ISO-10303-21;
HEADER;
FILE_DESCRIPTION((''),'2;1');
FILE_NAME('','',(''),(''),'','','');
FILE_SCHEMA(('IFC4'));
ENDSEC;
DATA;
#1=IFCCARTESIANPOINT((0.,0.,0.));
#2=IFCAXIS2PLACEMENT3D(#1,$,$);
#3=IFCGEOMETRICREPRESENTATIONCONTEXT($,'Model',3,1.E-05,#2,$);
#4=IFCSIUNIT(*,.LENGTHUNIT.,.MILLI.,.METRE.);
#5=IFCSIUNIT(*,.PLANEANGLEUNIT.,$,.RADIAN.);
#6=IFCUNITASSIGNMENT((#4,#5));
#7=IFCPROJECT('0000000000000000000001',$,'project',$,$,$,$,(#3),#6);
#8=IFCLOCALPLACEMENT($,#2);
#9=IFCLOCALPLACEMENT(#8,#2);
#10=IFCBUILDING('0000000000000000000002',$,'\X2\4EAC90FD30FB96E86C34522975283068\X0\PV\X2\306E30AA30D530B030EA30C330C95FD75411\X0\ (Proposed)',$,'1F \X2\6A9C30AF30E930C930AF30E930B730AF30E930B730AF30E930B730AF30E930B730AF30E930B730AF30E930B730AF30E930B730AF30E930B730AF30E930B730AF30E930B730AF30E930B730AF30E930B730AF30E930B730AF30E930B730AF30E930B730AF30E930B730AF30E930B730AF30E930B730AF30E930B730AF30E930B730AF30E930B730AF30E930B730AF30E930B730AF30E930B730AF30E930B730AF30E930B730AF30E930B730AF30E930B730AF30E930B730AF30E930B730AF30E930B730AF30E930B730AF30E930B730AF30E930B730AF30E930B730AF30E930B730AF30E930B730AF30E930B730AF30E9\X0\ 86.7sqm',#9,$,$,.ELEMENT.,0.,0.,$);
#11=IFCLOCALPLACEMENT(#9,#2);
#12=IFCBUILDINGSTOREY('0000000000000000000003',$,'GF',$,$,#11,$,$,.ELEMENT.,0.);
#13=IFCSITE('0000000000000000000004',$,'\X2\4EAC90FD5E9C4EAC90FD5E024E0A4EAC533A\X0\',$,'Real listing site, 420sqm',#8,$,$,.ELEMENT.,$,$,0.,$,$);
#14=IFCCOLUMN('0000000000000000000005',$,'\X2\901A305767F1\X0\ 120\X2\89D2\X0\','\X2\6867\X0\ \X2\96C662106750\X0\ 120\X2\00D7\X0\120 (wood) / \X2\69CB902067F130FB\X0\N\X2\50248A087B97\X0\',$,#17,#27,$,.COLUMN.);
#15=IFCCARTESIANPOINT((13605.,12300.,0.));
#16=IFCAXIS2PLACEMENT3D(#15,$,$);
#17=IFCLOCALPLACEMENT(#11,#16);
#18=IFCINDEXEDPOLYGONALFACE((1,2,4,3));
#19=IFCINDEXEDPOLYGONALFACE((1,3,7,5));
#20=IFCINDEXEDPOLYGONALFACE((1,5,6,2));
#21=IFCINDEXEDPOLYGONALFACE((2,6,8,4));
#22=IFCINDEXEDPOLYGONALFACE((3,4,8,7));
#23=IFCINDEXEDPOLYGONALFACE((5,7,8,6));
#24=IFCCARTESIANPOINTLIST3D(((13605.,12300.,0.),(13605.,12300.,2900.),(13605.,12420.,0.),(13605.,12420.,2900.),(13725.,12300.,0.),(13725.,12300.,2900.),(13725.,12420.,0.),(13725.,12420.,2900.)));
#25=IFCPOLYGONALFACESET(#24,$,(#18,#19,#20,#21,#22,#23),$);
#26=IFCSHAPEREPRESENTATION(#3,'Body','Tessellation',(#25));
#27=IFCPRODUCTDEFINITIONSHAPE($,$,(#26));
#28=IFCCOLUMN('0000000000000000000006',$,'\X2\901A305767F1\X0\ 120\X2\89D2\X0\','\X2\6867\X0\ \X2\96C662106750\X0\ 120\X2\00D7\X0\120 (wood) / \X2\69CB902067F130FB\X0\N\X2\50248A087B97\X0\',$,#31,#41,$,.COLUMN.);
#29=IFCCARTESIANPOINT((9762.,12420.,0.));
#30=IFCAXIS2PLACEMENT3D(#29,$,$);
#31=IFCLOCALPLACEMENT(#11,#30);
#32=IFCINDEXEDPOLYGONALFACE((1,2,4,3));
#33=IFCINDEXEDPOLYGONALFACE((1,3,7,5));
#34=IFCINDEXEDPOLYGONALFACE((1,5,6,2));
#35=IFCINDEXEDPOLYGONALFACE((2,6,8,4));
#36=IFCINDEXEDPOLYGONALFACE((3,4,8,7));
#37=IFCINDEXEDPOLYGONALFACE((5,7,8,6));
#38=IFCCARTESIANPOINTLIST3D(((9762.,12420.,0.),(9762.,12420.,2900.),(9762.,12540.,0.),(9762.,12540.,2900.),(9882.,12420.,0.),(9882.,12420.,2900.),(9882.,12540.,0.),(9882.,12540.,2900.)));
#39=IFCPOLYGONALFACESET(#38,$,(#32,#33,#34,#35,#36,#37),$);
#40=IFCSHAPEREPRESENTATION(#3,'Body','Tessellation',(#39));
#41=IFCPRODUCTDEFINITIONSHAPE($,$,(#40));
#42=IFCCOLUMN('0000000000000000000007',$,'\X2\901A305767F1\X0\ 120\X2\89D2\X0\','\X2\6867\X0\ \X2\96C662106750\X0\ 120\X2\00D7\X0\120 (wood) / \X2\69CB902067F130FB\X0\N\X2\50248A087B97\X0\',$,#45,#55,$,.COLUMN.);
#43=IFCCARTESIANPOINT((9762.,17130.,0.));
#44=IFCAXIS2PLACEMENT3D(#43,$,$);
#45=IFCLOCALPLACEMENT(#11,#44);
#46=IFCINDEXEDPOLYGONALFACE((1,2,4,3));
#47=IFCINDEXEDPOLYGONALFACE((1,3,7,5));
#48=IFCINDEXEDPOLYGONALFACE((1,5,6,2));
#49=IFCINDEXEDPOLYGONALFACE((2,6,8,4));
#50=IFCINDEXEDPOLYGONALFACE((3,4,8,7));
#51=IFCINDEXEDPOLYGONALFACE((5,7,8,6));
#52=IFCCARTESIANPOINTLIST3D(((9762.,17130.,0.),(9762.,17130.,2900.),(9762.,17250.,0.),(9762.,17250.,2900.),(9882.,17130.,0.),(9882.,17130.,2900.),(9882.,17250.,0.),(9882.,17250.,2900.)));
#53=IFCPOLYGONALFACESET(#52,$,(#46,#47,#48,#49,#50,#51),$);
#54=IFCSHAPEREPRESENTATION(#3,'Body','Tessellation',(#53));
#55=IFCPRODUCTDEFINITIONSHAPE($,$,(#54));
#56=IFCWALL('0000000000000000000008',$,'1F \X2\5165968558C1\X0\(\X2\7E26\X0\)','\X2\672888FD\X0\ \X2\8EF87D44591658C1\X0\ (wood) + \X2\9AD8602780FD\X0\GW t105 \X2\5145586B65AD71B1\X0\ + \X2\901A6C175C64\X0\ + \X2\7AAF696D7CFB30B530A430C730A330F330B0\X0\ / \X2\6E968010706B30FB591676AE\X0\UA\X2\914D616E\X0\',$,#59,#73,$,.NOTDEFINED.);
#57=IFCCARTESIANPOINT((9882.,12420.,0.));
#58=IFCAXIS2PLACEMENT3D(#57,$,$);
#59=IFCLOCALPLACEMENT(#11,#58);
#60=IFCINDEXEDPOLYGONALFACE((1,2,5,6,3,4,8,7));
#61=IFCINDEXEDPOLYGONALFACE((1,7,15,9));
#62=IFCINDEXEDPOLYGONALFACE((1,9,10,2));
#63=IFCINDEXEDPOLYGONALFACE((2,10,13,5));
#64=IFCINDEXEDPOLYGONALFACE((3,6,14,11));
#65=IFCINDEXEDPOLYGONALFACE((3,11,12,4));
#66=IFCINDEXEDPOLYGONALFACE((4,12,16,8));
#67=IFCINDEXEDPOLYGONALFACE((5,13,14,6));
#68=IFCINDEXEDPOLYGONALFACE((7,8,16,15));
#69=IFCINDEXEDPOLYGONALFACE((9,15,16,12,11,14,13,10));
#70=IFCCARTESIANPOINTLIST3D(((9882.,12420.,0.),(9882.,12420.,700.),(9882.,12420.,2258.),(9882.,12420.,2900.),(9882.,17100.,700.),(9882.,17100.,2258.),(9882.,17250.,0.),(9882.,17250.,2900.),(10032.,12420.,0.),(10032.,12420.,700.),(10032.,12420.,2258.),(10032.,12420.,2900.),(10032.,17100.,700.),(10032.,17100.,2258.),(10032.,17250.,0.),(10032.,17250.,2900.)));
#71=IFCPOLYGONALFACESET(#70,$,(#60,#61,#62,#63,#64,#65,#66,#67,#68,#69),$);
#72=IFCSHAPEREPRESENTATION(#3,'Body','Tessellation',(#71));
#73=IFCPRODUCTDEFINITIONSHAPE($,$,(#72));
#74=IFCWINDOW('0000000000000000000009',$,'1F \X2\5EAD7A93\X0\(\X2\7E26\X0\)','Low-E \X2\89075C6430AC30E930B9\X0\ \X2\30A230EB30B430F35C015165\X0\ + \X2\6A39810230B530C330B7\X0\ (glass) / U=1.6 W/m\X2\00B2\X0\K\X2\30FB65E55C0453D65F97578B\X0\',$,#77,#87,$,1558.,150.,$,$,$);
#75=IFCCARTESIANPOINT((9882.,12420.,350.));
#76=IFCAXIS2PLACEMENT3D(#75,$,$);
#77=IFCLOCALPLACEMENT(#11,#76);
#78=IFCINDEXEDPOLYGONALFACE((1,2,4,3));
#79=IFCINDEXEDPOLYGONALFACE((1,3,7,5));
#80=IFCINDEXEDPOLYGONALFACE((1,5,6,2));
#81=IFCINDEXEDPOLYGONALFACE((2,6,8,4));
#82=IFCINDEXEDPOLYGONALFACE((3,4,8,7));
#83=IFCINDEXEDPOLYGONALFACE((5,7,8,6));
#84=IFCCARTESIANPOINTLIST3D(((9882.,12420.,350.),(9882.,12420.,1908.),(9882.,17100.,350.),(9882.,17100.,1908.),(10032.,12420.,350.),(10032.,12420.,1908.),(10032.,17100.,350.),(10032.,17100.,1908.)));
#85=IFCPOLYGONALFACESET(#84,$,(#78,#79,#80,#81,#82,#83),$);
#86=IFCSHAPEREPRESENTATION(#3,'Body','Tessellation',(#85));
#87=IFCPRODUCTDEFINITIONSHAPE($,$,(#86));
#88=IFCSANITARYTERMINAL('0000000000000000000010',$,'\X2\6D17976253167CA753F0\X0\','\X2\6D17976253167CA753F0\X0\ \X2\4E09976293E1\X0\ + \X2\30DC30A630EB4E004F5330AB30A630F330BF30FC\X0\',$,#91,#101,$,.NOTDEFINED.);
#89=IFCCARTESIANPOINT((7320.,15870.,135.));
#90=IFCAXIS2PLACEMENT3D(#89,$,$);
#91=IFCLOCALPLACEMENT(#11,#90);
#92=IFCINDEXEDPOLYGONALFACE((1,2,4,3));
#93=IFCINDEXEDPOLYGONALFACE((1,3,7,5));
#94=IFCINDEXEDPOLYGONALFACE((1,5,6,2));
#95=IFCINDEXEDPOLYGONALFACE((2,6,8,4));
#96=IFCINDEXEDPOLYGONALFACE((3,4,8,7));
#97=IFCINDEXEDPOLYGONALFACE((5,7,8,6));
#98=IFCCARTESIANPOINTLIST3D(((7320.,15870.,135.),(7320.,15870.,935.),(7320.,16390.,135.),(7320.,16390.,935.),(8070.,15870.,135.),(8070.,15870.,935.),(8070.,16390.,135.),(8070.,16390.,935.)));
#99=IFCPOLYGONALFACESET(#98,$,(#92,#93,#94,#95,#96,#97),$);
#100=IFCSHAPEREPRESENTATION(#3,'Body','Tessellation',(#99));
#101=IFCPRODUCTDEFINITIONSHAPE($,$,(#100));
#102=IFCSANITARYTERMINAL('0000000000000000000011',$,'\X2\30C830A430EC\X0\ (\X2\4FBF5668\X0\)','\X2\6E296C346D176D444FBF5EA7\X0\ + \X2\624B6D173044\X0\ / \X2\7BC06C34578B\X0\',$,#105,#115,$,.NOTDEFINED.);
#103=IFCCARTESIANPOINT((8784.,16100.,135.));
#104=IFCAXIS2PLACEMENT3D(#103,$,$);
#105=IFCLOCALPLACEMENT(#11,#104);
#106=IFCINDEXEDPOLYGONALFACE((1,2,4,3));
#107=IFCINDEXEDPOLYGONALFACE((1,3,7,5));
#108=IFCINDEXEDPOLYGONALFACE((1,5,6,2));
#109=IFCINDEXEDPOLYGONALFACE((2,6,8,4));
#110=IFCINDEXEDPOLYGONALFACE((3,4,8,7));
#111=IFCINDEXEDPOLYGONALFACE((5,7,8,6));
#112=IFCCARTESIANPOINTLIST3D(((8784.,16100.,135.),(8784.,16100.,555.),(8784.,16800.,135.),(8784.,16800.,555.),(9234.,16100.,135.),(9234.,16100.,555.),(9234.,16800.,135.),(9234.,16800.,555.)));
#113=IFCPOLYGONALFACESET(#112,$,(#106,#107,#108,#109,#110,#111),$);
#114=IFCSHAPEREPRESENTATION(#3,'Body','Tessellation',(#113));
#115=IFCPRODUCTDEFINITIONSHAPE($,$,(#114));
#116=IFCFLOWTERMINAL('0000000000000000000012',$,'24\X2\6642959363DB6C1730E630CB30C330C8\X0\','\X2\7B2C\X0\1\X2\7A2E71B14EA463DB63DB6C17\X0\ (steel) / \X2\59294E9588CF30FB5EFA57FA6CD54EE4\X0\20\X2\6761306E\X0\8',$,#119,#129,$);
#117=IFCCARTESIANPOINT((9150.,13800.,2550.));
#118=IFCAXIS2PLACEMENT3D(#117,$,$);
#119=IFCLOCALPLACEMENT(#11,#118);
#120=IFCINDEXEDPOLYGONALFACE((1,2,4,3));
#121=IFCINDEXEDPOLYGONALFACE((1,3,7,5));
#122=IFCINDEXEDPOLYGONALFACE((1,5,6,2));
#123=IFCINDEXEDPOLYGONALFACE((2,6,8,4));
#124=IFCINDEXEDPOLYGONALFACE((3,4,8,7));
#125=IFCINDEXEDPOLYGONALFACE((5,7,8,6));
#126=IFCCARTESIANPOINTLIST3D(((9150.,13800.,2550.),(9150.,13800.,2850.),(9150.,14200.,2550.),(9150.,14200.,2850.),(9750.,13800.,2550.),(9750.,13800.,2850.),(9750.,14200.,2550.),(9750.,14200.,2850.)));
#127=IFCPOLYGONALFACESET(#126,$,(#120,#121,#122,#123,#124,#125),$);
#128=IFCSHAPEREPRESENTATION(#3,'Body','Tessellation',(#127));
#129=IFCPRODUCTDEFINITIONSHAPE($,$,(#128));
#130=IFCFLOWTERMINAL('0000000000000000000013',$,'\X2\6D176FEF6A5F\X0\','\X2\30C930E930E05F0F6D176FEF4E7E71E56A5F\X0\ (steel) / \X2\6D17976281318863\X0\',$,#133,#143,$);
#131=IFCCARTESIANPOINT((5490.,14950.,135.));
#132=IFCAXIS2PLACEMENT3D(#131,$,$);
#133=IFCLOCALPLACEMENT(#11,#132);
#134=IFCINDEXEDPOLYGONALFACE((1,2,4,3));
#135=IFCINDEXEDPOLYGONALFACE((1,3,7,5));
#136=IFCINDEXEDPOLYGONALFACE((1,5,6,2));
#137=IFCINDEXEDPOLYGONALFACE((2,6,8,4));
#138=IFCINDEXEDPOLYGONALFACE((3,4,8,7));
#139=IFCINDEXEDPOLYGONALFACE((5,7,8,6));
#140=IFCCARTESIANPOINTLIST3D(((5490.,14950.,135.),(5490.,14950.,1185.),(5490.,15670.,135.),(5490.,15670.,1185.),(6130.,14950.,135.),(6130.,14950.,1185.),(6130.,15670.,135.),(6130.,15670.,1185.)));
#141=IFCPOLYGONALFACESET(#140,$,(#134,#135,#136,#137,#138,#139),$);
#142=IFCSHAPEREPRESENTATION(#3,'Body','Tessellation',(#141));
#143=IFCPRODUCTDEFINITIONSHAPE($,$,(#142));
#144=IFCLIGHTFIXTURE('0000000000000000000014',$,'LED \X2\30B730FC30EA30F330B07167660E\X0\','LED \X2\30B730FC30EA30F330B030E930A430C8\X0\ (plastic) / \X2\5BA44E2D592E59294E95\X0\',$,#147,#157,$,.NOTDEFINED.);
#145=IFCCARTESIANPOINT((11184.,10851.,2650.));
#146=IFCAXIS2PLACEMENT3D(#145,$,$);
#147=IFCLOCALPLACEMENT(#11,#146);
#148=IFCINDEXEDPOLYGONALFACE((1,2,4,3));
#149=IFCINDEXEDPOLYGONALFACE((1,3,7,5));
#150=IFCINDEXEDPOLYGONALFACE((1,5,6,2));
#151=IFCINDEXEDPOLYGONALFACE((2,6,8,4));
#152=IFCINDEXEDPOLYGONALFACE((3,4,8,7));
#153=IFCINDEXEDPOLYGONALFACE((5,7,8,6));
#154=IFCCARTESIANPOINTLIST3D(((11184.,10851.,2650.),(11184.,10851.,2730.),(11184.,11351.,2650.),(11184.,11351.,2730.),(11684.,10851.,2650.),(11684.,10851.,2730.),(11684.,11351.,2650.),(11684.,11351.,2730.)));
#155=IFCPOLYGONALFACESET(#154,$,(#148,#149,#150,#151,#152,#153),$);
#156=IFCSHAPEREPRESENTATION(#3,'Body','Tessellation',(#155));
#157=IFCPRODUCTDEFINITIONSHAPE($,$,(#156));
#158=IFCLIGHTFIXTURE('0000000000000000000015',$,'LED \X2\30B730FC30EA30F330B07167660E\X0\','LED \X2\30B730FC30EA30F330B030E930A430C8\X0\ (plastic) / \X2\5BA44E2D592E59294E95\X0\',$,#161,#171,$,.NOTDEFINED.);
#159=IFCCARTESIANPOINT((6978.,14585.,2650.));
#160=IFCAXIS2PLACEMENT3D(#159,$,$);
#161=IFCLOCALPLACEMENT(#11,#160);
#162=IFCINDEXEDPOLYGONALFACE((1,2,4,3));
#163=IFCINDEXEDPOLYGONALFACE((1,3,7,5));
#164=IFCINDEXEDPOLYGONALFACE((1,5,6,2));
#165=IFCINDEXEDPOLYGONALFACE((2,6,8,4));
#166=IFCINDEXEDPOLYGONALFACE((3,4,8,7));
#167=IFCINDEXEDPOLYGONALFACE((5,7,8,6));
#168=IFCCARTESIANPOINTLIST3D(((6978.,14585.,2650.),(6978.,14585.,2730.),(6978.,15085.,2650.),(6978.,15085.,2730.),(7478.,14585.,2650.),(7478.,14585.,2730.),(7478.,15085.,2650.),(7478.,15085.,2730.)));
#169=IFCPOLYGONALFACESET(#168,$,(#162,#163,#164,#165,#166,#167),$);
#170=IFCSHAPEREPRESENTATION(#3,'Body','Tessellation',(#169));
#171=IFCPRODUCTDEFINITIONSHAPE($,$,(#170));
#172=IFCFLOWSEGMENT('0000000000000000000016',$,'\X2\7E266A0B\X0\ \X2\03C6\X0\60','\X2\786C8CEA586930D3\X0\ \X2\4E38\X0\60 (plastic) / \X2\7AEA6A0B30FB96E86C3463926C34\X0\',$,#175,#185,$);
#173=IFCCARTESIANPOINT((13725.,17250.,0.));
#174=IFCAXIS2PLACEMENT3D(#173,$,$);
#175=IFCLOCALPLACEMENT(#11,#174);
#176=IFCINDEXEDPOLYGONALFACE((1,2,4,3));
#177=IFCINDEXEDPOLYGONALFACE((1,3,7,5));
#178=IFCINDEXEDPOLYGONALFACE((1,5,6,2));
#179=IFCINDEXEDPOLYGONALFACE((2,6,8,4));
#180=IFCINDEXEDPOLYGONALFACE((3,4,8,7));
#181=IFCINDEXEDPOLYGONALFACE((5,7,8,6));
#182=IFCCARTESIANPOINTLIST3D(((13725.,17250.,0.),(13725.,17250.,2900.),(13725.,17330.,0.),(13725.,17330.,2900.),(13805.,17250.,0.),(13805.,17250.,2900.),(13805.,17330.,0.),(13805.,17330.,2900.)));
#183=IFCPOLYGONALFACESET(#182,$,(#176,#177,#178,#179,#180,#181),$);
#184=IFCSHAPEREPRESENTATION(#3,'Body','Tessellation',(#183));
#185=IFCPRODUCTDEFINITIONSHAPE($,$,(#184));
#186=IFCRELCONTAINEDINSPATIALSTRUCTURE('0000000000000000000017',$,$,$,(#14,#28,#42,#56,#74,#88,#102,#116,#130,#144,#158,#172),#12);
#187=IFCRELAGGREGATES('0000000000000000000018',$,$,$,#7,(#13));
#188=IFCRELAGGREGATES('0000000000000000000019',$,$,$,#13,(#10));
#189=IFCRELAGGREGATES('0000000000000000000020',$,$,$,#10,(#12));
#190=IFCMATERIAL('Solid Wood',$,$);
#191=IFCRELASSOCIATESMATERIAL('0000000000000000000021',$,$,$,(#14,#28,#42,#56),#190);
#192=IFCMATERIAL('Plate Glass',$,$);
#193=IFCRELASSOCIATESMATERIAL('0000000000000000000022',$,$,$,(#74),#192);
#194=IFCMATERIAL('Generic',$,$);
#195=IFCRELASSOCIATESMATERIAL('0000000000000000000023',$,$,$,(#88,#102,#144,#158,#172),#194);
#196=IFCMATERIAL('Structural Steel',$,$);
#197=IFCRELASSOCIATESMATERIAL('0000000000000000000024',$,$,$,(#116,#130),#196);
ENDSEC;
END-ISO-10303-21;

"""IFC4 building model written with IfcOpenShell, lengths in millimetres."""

from ifc_helpers import new_model, si_unit, frame, frame_2d, origin, place, context, project, spatial, rectangle, extrude, material, element, fill, save


model = new_model("IFC4")

# Units and contexts
model_context = context("Model", 3, precision=1e-05, world=origin())
ifc_project = project(units=[si_unit("LENGTHUNIT", "METRE", prefix="MILLI"), si_unit("PLANEANGLEUNIT", "RADIAN")], contexts=[model_context])

# Site, building, storey
site_placement = place(None, origin())
site = spatial("IfcSite", under=ifc_project, at=site_placement, Name="京都府京都市上京区", ObjectType="Real listing site, 420sqm", CompositionType="ELEMENT", RefElevation=0.0)
building_placement = place(site_placement, origin())
building = spatial("IfcBuilding", under=site, at=building_placement, Name="京都・雨水利用とPVのオフグリッド志向 (Proposed)", ObjectType="1F 檜クラドクラシクラシクラシクラシクラシクラシクラシクラシクラシクラシクラシクラシクラシクラシクラシクラシクラシクラシクラシクラシクラシクラシクラシクラシクラシクラシクラシクラシクラシクラシクラシクラシクラシクラシクラシクラシクラシクラシクラ 86.7sqm", CompositionType="ELEMENT", ElevationOfRefHeight=0.0, ElevationOfTerrain=0.0)
storey_placement = place(building_placement, origin())
storey = spatial("IfcBuildingStorey", under=building, at=storey_placement, Name="GF", CompositionType="ELEMENT", Elevation=0.0)

# Columns
ifc_material_1 = material(Name="Solid Wood")
column_1_placement = place(storey_placement, frame((13605.0, 12300.0, 0.0)))
element("IfcColumn", 1, at=column_1_placement, inside=storey, material=ifc_material_1, Name="通し柱 120角", Description="桧 集成材 120×120 (wood) / 構造柱・N値計算", PredefinedType="COLUMN", context=model_context, shape_type="SweptSolid", body=[
    extrude(rectangle(XDim=120.0, YDim=120.0, at=frame_2d((60.0, 60.0))), frame((13605.0, 12300.0, 0.0)), (0.0, 0.0, 1.0), 2900.0),
])
column_2_placement = place(storey_placement, frame((9762.0, 12420.0, 0.0)))
element("IfcColumn", 2, at=column_2_placement, inside=storey, material=ifc_material_1, Name="通し柱 120角", Description="桧 集成材 120×120 (wood) / 構造柱・N値計算", PredefinedType="COLUMN", context=model_context, shape_type="SweptSolid", body=[
    extrude(rectangle(XDim=120.0, YDim=120.0, at=frame_2d((60.0, 60.0))), frame((9762.0, 12420.0, 0.0)), (0.0, 0.0, 1.0), 2900.0),
])
column_3_placement = place(storey_placement, frame((9762.0, 17130.0, 0.0)))
element("IfcColumn", 3, at=column_3_placement, inside=storey, material=ifc_material_1, Name="通し柱 120角", Description="桧 集成材 120×120 (wood) / 構造柱・N値計算", PredefinedType="COLUMN", context=model_context, shape_type="SweptSolid", body=[
    extrude(rectangle(XDim=120.0, YDim=120.0, at=frame_2d((60.0, 60.0))), frame((9762.0, 17130.0, 0.0)), (0.0, 0.0, 1.0), 2900.0),
])

# Wall, opening, window
wall_1_placement = place(storey_placement, frame((9882.0, 12420.0, 0.0)))
wall_1 = element("IfcWall", 4, at=wall_1_placement, inside=storey, material=ifc_material_1, Name="1F 入隅壁(縦)", Description="木製 軸組外壁 (wood) + 高性能GW t105 充填断熱 + 通気層 + 窯業系サイディング / 準耐火・外皮UA配慮", PredefinedType="NOTDEFINED", context=model_context, shape_type="SweptSolid", body=[
    extrude(rectangle(XDim=150.0, YDim=4830.0, at=frame_2d((75.0, 2415.0))), frame((9882.0, 12420.0, 0.0)), (0.0, 0.0, 1.0), 2900.0),
])
opening_placement = place(storey_placement, frame((9882.0, 12420.0, 350.0)))
opening = element("IfcOpeningElement", 5, at=opening_placement, cuts=wall_1, PredefinedType="NOTDEFINED", context=model_context, shape_type="SweptSolid", body=[
    extrude(rectangle(XDim=150.0, YDim=4680.0, at=frame_2d((75.0, 2340.0))), frame((9882.0, 12420.0, 350.0)), (0.0, 0.0, 1.0), 1558.0),
])
ifc_material_2 = material(Name="Plate Glass")
window_placement = place(storey_placement, frame((9882.0, 12420.0, 350.0)))
window = element("IfcWindow", 6, at=window_placement, inside=storey, material=ifc_material_2, Name="1F 庭窓(縦)", Description="Low-E 複層ガラス アルゴン封入 + 樹脂サッシ (glass) / U=1.6 W/m²K・日射取得型", OverallHeight=1558.0, OverallWidth=150.0, context=model_context, shape_type="SweptSolid", body=[
    extrude(rectangle(XDim=150.0, YDim=4680.0, at=frame_2d((75.0, 2340.0))), frame((9882.0, 12420.0, 350.0)), (0.0, 0.0, 1.0), 1558.0),
])
fill(opening, window)

# Sanitary terminals
ifc_material_3 = material(Name="Generic")
sanitary_terminal_1_placement = place(storey_placement, frame((7320.0, 15870.0, 135.0)))
element("IfcSanitaryTerminal", 7, at=sanitary_terminal_1_placement, inside=storey, material=ifc_material_3, Name="洗面化粧台", Description="洗面化粧台 三面鏡 + ボウル一体カウンター", PredefinedType="NOTDEFINED", context=model_context, shape_type="SweptSolid", body=[
    extrude(rectangle(XDim=750.0, YDim=520.0, at=frame_2d((375.0, 260.0))), frame((7320.0, 15870.0, 135.0)), (0.0, 0.0, 1.0), 800.0),
])
sanitary_terminal_2_placement = place(storey_placement, frame((8784.0, 16100.0, 135.0)))
element("IfcSanitaryTerminal", 8, at=sanitary_terminal_2_placement, inside=storey, material=ifc_material_3, Name="トイレ (便器)", Description="温水洗浄便座 + 手洗い / 節水型", PredefinedType="NOTDEFINED", context=model_context, shape_type="SweptSolid", body=[
    extrude(rectangle(XDim=450.0, YDim=700.0, at=frame_2d((225.0, 350.0))), frame((8784.0, 16100.0, 135.0)), (0.0, 0.0, 1.0), 420.0),
])

# Flow terminals
ifc_material_4 = material(Name="Structural Steel")
flow_terminal_1_placement = place(storey_placement, frame((9150.0, 13800.0, 2550.0)))
element("IfcFlowTerminal", 9, at=flow_terminal_1_placement, inside=storey, material=ifc_material_4, Name="24時間換気ユニット", Description="第1種熱交換換気 (steel) / 天井裏・建基法令20条の8", context=model_context, shape_type="SweptSolid", body=[
    extrude(rectangle(XDim=600.0, YDim=400.0, at=frame_2d((300.0, 200.0))), frame((9150.0, 13800.0, 2550.0)), (0.0, 0.0, 1.0), 300.0),
])
flow_terminal_2_placement = place(storey_placement, frame((5490.0, 14950.0, 135.0)))
element("IfcFlowTerminal", 10, at=flow_terminal_2_placement, inside=storey, material=ifc_material_4, Name="洗濯機", Description="ドラム式洗濯乾燥機 (steel) / 洗面脱衣", context=model_context, shape_type="SweptSolid", body=[
    extrude(rectangle(XDim=640.0, YDim=720.0, at=frame_2d((320.0, 360.0))), frame((5490.0, 14950.0, 135.0)), (0.0, 0.0, 1.0), 1050.0),
])

# Light fixtures
light_fixture_1_placement = place(storey_placement, frame((11184.0, 10851.0, 2650.0)))
element("IfcLightFixture", 11, at=light_fixture_1_placement, inside=storey, material=ifc_material_3, Name="LED シーリング照明", Description="LED シーリングライト (plastic) / 室中央天井", PredefinedType="NOTDEFINED", context=model_context, shape_type="SweptSolid", body=[
    extrude(rectangle(XDim=500.0, YDim=500.0, at=frame_2d((250.0, 250.0))), frame((11184.0, 10851.0, 2650.0)), (0.0, 0.0, 1.0), 80.0),
])
light_fixture_2_placement = place(storey_placement, frame((6978.0, 14585.0, 2650.0)))
element("IfcLightFixture", 12, at=light_fixture_2_placement, inside=storey, material=ifc_material_3, Name="LED シーリング照明", Description="LED シーリングライト (plastic) / 室中央天井", PredefinedType="NOTDEFINED", context=model_context, shape_type="SweptSolid", body=[
    extrude(rectangle(XDim=500.0, YDim=500.0, at=frame_2d((250.0, 250.0))), frame((6978.0, 14585.0, 2650.0)), (0.0, 0.0, 1.0), 80.0),
])

# Flow segment
flow_segment_placement = place(storey_placement, frame((13725.0, 17250.0, 0.0)))
element("IfcFlowSegment", 13, at=flow_segment_placement, inside=storey, material=ifc_material_3, Name="縦樋 φ60", Description="硬質塩ビ 丸60 (plastic) / 竪樋・雨水排水", context=model_context, shape_type="SweptSolid", body=[
    extrude(rectangle(XDim=80.0, YDim=80.0, at=frame_2d((40.0, 40.0))), frame((13725.0, 17250.0, 0.0)), (0.0, 0.0, 1.0), 2900.0),
])

save(model, "model.ifc")
